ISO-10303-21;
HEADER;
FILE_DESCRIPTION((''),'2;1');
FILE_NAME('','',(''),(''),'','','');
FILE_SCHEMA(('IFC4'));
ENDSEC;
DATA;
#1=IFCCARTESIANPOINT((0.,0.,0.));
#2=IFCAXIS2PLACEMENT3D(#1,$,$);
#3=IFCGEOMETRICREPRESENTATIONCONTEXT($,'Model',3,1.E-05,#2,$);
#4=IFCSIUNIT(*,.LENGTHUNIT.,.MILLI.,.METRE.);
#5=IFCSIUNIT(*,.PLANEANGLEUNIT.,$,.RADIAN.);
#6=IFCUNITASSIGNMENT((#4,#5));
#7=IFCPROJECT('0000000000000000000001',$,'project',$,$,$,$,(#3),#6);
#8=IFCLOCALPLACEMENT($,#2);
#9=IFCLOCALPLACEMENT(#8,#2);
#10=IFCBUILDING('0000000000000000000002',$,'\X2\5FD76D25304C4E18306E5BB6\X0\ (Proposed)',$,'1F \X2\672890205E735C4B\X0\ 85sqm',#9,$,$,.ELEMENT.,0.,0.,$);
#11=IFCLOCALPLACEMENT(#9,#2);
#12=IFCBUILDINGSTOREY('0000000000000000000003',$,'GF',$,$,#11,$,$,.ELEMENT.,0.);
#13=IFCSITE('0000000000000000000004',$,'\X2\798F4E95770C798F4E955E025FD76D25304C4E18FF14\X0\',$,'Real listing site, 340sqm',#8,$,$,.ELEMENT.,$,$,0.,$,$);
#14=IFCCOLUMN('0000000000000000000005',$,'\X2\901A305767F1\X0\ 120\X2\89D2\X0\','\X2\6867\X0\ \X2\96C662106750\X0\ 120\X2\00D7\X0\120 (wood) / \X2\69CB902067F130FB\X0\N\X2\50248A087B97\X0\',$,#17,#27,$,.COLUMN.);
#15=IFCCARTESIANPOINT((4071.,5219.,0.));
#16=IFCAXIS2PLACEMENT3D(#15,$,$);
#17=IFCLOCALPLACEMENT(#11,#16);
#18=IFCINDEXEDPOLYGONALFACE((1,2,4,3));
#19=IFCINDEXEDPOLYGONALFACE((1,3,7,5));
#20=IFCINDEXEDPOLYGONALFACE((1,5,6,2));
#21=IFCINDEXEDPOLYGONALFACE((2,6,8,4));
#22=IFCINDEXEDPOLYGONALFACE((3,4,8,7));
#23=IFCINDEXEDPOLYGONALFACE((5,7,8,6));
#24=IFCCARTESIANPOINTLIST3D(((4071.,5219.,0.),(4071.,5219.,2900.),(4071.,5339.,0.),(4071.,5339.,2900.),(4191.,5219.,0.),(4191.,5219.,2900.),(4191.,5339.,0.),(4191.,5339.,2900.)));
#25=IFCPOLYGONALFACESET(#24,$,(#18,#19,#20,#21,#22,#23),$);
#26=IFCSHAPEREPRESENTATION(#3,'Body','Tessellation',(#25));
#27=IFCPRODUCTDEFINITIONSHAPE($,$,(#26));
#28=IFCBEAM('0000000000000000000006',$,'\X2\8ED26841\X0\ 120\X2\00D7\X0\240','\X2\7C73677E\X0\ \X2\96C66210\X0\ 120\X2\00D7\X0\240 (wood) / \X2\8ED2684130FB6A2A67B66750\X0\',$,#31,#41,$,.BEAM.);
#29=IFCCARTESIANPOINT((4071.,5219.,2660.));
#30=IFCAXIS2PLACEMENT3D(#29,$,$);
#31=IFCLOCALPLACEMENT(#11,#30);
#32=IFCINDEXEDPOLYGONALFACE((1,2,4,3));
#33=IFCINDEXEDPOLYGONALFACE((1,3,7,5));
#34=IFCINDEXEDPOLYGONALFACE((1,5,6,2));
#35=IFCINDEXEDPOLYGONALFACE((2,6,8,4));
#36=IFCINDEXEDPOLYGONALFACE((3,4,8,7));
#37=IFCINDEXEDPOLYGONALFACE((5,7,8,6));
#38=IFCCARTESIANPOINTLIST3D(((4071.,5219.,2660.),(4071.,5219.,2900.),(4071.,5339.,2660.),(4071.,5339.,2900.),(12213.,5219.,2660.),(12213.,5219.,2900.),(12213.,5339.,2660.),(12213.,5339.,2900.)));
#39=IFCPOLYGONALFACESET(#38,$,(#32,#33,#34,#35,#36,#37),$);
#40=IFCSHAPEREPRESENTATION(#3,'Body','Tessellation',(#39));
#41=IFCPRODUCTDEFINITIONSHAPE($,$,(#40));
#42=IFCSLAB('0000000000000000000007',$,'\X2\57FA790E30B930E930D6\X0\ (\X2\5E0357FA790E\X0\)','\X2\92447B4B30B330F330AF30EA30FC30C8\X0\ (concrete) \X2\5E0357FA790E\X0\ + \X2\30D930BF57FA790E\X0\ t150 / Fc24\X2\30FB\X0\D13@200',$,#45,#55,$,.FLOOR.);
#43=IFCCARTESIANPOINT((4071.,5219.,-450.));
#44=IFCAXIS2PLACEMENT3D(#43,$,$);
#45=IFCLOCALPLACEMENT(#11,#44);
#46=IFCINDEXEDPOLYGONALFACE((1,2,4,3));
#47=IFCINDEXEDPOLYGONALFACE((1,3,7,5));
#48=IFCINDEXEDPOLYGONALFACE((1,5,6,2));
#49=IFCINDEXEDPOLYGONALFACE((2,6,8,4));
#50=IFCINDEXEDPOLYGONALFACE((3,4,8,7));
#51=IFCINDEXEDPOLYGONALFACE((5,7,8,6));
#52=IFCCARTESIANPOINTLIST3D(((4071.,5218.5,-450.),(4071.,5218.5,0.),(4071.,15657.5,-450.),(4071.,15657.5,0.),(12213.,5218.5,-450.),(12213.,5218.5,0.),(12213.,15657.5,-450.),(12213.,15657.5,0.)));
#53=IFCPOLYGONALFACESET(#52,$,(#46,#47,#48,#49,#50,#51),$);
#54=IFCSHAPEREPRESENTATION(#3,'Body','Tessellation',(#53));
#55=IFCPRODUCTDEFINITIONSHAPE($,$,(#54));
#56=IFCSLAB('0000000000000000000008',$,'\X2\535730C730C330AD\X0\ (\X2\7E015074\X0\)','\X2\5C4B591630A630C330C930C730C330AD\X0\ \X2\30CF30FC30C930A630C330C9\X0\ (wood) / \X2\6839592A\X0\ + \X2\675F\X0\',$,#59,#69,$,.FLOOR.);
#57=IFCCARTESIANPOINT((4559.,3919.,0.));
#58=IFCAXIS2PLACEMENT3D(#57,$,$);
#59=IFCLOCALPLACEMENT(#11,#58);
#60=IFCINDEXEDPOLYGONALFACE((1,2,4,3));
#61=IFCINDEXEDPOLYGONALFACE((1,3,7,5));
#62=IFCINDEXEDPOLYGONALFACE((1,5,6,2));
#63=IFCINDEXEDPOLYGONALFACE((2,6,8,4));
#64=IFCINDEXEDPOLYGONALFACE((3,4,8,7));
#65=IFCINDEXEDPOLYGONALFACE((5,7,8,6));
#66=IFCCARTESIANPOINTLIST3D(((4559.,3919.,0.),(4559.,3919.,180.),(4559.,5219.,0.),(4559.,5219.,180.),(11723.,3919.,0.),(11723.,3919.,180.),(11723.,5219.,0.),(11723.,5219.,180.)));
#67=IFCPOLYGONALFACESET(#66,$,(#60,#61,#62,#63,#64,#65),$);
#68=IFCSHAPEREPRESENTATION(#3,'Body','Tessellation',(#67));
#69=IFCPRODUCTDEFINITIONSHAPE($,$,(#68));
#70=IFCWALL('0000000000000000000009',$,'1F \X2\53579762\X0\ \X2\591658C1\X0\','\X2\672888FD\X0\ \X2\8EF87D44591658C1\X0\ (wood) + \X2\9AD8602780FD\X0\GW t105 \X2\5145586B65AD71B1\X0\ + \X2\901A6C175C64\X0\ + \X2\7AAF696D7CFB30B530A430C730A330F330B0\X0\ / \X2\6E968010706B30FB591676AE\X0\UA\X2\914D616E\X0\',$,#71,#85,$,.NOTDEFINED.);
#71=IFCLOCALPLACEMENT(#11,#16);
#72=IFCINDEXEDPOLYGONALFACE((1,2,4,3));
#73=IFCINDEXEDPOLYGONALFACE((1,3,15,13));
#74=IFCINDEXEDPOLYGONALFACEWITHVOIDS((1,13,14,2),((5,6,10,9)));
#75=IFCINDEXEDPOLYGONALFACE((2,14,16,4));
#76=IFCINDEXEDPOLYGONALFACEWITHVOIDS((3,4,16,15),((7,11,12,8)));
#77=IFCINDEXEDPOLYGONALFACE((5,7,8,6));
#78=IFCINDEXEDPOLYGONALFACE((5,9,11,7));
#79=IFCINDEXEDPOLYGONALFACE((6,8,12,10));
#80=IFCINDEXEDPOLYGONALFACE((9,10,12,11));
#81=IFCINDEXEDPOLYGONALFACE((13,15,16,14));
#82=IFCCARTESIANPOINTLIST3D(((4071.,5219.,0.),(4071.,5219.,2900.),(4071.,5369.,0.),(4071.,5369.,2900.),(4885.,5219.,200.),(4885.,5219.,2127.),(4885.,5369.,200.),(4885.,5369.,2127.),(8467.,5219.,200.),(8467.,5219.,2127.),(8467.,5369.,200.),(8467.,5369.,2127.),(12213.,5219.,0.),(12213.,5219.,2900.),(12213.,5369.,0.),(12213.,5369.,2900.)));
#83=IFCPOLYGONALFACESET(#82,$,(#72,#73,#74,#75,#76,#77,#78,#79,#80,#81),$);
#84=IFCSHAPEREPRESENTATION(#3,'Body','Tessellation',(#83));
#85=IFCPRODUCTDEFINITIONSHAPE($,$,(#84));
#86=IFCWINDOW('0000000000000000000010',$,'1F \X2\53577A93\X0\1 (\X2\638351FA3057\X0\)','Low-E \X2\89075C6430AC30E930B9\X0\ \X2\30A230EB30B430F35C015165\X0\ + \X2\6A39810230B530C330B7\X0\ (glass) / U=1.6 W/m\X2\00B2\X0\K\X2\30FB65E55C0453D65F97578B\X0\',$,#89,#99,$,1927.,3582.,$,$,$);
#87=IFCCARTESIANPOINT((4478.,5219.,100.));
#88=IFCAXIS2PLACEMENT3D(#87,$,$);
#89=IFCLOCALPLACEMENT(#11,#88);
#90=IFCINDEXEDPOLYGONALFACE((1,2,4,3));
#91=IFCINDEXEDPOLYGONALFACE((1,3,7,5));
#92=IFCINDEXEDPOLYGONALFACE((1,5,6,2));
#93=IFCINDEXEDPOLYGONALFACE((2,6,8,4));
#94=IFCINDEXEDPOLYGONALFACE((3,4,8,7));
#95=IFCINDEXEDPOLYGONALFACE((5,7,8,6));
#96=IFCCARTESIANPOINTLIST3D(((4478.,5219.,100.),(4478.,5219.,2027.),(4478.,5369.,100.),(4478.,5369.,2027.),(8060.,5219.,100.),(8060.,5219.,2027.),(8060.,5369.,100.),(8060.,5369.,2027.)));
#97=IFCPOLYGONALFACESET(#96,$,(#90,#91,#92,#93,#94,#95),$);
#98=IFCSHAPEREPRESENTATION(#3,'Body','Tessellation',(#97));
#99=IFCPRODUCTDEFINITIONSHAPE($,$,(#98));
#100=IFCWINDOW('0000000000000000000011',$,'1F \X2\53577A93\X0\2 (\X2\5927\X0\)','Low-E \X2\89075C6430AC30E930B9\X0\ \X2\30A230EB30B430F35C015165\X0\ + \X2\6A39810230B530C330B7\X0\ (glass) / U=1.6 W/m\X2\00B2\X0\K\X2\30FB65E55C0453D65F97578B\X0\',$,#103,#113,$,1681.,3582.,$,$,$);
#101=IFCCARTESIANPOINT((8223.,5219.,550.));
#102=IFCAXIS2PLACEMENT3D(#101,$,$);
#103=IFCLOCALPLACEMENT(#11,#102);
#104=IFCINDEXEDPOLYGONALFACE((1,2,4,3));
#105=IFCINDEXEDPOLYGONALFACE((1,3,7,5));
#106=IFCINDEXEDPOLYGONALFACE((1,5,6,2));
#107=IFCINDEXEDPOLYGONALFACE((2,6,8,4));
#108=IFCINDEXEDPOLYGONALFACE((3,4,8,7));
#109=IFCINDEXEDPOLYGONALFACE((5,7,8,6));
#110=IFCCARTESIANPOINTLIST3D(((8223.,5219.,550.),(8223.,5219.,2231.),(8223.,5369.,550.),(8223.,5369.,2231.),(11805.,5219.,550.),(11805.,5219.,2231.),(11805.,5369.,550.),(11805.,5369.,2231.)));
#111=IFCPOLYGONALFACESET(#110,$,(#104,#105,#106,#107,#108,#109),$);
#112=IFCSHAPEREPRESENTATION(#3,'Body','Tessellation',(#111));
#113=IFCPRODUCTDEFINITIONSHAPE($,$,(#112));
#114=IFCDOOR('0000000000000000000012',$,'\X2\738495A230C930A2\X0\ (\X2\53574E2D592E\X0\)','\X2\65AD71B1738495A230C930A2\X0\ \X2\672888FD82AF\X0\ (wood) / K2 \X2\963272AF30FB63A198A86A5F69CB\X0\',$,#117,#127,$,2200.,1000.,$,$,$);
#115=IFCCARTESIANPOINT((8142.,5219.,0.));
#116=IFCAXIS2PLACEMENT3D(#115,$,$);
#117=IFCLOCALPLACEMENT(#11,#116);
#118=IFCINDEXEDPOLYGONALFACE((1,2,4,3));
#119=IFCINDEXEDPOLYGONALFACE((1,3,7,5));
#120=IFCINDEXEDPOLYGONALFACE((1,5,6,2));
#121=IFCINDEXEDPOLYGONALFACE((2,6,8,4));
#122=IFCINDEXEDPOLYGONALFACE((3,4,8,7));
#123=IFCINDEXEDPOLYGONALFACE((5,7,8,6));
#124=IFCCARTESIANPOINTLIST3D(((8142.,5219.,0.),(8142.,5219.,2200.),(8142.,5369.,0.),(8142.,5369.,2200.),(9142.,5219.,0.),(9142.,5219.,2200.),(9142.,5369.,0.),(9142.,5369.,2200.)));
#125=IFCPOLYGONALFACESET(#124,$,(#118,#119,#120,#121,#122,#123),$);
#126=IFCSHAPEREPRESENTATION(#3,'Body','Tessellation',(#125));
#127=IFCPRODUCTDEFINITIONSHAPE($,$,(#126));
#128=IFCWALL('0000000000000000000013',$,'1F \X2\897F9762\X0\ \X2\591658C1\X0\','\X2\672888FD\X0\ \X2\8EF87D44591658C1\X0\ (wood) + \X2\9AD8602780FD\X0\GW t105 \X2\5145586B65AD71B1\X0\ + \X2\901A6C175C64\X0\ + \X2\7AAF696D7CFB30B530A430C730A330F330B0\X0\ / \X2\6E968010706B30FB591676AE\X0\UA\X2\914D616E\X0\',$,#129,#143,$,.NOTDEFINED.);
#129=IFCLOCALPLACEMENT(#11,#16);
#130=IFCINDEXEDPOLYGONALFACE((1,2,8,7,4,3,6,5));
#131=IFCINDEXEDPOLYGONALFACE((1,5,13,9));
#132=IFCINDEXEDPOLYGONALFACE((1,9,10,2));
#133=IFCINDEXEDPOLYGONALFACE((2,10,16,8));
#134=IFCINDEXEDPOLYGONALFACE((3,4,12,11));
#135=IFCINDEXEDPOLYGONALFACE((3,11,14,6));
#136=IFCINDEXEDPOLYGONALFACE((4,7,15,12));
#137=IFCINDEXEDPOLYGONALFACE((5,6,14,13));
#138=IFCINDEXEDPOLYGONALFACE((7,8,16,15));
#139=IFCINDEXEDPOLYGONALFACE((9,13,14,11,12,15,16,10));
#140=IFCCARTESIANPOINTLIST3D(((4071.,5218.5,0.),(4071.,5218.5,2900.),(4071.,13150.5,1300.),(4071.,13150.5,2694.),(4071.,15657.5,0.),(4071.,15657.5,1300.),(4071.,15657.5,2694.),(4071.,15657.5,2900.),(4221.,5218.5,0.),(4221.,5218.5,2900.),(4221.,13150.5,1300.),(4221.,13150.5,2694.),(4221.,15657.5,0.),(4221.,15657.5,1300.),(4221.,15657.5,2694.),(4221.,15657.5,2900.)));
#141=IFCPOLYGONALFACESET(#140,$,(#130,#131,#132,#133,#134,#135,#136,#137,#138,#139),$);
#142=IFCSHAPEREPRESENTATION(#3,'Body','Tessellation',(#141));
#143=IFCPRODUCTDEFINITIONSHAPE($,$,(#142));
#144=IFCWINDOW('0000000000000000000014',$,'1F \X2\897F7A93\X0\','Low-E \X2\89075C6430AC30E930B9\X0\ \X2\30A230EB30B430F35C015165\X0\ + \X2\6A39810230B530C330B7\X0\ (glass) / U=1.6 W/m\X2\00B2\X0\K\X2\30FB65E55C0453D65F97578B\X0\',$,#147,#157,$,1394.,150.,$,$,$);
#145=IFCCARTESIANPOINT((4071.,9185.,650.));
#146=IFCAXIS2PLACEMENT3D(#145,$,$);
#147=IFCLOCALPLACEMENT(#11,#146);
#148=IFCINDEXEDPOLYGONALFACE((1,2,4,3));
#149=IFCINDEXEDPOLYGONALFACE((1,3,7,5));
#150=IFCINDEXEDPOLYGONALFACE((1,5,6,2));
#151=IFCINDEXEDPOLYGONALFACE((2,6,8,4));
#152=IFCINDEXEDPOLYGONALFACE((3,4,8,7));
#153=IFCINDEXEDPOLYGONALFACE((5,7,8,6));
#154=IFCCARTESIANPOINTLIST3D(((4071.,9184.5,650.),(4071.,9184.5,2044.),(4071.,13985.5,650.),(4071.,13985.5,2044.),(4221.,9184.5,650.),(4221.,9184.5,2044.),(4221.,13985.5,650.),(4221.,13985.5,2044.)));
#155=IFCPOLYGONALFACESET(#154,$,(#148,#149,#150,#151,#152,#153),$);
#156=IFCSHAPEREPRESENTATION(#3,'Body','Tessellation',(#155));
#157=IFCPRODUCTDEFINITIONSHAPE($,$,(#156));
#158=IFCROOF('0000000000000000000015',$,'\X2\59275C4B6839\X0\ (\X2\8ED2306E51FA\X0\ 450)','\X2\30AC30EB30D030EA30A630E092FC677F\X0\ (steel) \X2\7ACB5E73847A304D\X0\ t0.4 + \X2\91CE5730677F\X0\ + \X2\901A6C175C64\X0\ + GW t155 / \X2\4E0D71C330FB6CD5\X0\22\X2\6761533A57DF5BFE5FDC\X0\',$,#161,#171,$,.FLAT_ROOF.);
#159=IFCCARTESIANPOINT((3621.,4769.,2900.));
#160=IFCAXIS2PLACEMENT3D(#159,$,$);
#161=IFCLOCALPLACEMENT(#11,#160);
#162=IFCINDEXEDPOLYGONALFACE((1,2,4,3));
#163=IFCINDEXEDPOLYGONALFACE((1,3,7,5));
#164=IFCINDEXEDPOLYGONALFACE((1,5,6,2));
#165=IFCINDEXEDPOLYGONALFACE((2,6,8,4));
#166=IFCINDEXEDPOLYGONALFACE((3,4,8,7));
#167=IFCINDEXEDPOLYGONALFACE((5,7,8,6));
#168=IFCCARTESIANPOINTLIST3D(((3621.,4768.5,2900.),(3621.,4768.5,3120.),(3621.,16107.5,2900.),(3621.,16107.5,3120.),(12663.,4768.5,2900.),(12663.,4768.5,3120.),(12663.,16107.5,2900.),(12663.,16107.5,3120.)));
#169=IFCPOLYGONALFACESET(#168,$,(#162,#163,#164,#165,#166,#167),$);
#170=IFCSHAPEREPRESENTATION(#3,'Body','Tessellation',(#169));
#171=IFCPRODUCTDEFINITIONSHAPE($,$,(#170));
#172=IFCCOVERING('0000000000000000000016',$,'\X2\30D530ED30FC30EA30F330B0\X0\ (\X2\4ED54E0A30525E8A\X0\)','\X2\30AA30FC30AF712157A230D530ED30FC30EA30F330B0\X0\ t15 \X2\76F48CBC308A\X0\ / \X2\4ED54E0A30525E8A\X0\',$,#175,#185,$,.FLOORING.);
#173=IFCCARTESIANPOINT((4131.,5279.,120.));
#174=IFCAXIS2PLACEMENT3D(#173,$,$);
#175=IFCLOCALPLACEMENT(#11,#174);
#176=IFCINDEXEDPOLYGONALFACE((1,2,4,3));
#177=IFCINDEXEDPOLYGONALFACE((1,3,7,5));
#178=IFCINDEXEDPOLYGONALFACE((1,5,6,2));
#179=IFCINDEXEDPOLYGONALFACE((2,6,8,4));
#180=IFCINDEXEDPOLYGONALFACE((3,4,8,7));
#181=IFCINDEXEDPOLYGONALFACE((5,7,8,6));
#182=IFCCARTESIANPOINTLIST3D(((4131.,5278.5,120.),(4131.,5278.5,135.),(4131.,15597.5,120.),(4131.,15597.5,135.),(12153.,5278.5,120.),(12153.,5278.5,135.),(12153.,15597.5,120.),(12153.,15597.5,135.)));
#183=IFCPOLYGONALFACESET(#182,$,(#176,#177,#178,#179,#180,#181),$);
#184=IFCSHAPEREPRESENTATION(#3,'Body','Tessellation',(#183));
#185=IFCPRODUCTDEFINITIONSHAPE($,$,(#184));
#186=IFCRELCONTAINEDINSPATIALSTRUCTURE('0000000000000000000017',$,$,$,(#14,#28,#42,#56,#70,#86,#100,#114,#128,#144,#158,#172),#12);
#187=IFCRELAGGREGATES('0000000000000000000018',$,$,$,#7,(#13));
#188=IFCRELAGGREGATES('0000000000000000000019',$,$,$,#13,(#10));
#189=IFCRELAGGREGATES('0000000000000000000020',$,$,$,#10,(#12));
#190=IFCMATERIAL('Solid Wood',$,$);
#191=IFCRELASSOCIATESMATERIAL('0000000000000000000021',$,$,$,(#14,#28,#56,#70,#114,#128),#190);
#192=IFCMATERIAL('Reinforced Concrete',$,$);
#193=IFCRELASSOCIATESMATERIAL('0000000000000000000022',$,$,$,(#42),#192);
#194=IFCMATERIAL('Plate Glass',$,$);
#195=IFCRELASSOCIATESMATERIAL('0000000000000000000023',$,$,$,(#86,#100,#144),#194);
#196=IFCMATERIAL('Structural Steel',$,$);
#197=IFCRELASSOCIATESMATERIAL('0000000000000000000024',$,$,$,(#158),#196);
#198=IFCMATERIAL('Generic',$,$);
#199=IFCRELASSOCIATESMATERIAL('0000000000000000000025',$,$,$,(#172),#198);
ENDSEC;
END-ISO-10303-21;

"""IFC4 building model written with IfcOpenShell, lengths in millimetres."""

from ifc_helpers import new_model, si_unit, frame, frame_2d, origin, place, context, project, spatial, rectangle, extrude, material, element, fill, save


model = new_model("IFC4")

# Units and contexts
model_context = context("Model", 3, precision=1e-05, world=origin())
ifc_project = project(units=[si_unit("LENGTHUNIT", "METRE", prefix="MILLI"), si_unit("PLANEANGLEUNIT", "RADIAN")], contexts=[model_context])

# Site, building, storey
site_placement = place(None, origin())
site = spatial("IfcSite", under=ifc_project, at=site_placement, Name="福井県福井市志津が丘４", ObjectType="Real listing site, 340sqm", CompositionType="ELEMENT", RefElevation=0.0)
building_placement = place(site_placement, origin())
building = spatial("IfcBuilding", under=site, at=building_placement, Name="志津が丘の家 (Proposed)", ObjectType="1F 木造平屋 85sqm", CompositionType="ELEMENT", ElevationOfRefHeight=0.0, ElevationOfTerrain=0.0)
storey_placement = place(building_placement, origin())
storey = spatial("IfcBuildingStorey", under=building, at=storey_placement, Name="GF", CompositionType="ELEMENT", Elevation=0.0)

# Column
ifc_material_1 = material(Name="Solid Wood")
column_1_placement = place(storey_placement, frame((4071.0, 5219.0, 0.0)))
element("IfcColumn", 1, at=column_1_placement, inside=storey, material=ifc_material_1, Name="通し柱 120角", Description="桧 集成材 120×120 (wood) / 構造柱・N値計算", PredefinedType="COLUMN", context=model_context, shape_type="SweptSolid", body=[
    extrude(rectangle(XDim=120.0, YDim=120.0, at=frame_2d((60.0, 60.0))), frame((4071.0, 5219.0, 0.0)), (0.0, 0.0, 1.0), 2900.0),
])

# Beam
beam_1_placement = place(storey_placement, frame((4071.0, 5219.0, 2660.0)))
element("IfcBeam", 2, at=beam_1_placement, inside=storey, material=ifc_material_1, Name="軒桁 120×240", Description="米松 集成 120×240 (wood) / 軒桁・横架材", PredefinedType="BEAM", context=model_context, shape_type="SweptSolid", body=[
    extrude(rectangle(XDim=8142.0, YDim=120.0, at=frame_2d((4071.0, 60.0))), frame((4071.0, 5219.0, 2660.0)), (0.0, 0.0, 1.0), 240.0),
])

# Slabs
ifc_material_2 = material(Name="Reinforced Concrete")
slab_1_placement = place(storey_placement, frame((4071.0, 5219.0, -450.0)))
element("IfcSlab", 3, at=slab_1_placement, inside=storey, material=ifc_material_2, Name="基礎スラブ (布基礎)", Description="鉄筋コンクリート (concrete) 布基礎 + ベタ基礎 t150 / Fc24・D13@200", PredefinedType="FLOOR", context=model_context, shape_type="SweptSolid", body=[
    extrude(rectangle(XDim=8142.0, YDim=10439.0, at=frame_2d((4071.0, 5219.0))), frame((4071.0, 5219.0, -450.0)), (0.0, 0.0, 1.0), 450.0),
])
slab_2_placement = place(storey_placement, frame((4559.0, 3919.0, 0.0)))
element("IfcSlab", 4, at=slab_2_placement, inside=storey, material=ifc_material_1, Name="南デッキ (縁側)", Description="屋外ウッドデッキ ハードウッド (wood) / 根太 + 束", PredefinedType="FLOOR", context=model_context, shape_type="SweptSolid", body=[
    extrude(rectangle(XDim=7164.0, YDim=1300.0, at=frame_2d((3582.0, 650.0))), frame((4559.0, 3919.0, 0.0)), (0.0, 0.0, 1.0), 180.0),
])

# Wall, openings, windows, door
wall_1_placement = place(storey_placement, frame((4071.0, 5219.0, 0.0)))
wall_1 = element("IfcWall", 5, at=wall_1_placement, inside=storey, material=ifc_material_1, Name="1F 南面 外壁", Description="木製 軸組外壁 (wood) + 高性能GW t105 充填断熱 + 通気層 + 窯業系サイディング / 準耐火・外皮UA配慮", PredefinedType="NOTDEFINED", context=model_context, shape_type="SweptSolid", body=[
    extrude(rectangle(XDim=8142.0, YDim=150.0, at=frame_2d((4071.0, 75.0))), frame((4071.0, 5219.0, 0.0)), (0.0, 0.0, 1.0), 2900.0),
])
opening_1_placement = place(storey_placement, frame((4478.0, 5219.0, 100.0)))
opening_1 = element("IfcOpeningElement", 6, at=opening_1_placement, cuts=wall_1, PredefinedType="NOTDEFINED", context=model_context, shape_type="SweptSolid", body=[
    extrude(rectangle(XDim=3582.0, YDim=150.0, at=frame_2d((1791.0, 75.0))), frame((4478.0, 5219.0, 100.0)), (0.0, 0.0, 1.0), 1927.0),
])
opening_2_placement = place(storey_placement, frame((8223.0, 5219.0, 550.0)))
opening_2 = element("IfcOpeningElement", 7, at=opening_2_placement, cuts=wall_1, PredefinedType="NOTDEFINED", context=model_context, shape_type="SweptSolid", body=[
    extrude(rectangle(XDim=3582.0, YDim=150.0, at=frame_2d((1791.0, 75.0))), frame((8223.0, 5219.0, 550.0)), (0.0, 0.0, 1.0), 1681.0),
])
opening_3_placement = place(storey_placement, frame((8142.0, 5219.0, 0.0)))
opening_3 = element("IfcOpeningElement", 8, at=opening_3_placement, cuts=wall_1, PredefinedType="NOTDEFINED", context=model_context, shape_type="SweptSolid", body=[
    extrude(rectangle(XDim=1000.0, YDim=150.0, at=frame_2d((500.0, 75.0))), frame((8142.0, 5219.0, 0.0)), (0.0, 0.0, 1.0), 2200.0),
])
ifc_material_3 = material(Name="Plate Glass")
window_1_placement = place(storey_placement, frame((4478.0, 5219.0, 100.0)))
window_1 = element("IfcWindow", 9, at=window_1_placement, inside=storey, material=ifc_material_3, Name="1F 南窓1 (掃出し)", Description="Low-E 複層ガラス アルゴン封入 + 樹脂サッシ (glass) / U=1.6 W/m²K・日射取得型", OverallHeight=1927.0, OverallWidth=3582.0, context=model_context, shape_type="SweptSolid", body=[
    extrude(rectangle(XDim=3582.0, YDim=150.0, at=frame_2d((1791.0, 75.0))), frame((4478.0, 5219.0, 100.0)), (0.0, 0.0, 1.0), 1927.0),
])
fill(opening_1, window_1)
window_2_placement = place(storey_placement, frame((8223.0, 5219.0, 550.0)))
window_2 = element("IfcWindow", 10, at=window_2_placement, inside=storey, material=ifc_material_3, Name="1F 南窓2 (大)", Description="Low-E 複層ガラス アルゴン封入 + 樹脂サッシ (glass) / U=1.6 W/m²K・日射取得型", OverallHeight=1681.0, OverallWidth=3582.0, context=model_context, shape_type="SweptSolid", body=[
    extrude(rectangle(XDim=3582.0, YDim=150.0, at=frame_2d((1791.0, 75.0))), frame((8223.0, 5219.0, 550.0)), (0.0, 0.0, 1.0), 1681.0),
])
fill(opening_2, window_2)
door_placement = place(storey_placement, frame((8142.0, 5219.0, 0.0)))
door = element("IfcDoor", 11, at=door_placement, inside=storey, material=ifc_material_1, Name="玄関ドア (南中央)", Description="断熱玄関ドア 木製芯 (wood) / K2 防犯・採風機構", OverallHeight=2200.0, OverallWidth=1000.0, context=model_context, shape_type="SweptSolid", body=[
    extrude(rectangle(XDim=1000.0, YDim=150.0, at=frame_2d((500.0, 75.0))), frame((8142.0, 5219.0, 0.0)), (0.0, 0.0, 1.0), 2200.0),
])
fill(opening_3, door)

# Wall, opening, window
wall_2_placement = place(storey_placement, frame((4071.0, 5219.0, 0.0)))
wall_2 = element("IfcWall", 12, at=wall_2_placement, inside=storey, material=ifc_material_1, Name="1F 西面 外壁", Description="木製 軸組外壁 (wood) + 高性能GW t105 充填断熱 + 通気層 + 窯業系サイディング / 準耐火・外皮UA配慮", PredefinedType="NOTDEFINED", context=model_context, shape_type="SweptSolid", body=[
    extrude(rectangle(XDim=150.0, YDim=10439.0, at=frame_2d((75.0, 5219.0))), frame((4071.0, 5219.0, 0.0)), (0.0, 0.0, 1.0), 2900.0),
])
opening_4_placement = place(storey_placement, frame((4071.0, 9185.0, 650.0)))
opening_4 = element("IfcOpeningElement", 13, at=opening_4_placement, cuts=wall_2, PredefinedType="NOTDEFINED", context=model_context, shape_type="SweptSolid", body=[
    extrude(rectangle(XDim=150.0, YDim=4801.0, at=frame_2d((75.0, 2400.0))), frame((4071.0, 9185.0, 650.0)), (0.0, 0.0, 1.0), 1394.0),
])
window_3_placement = place(storey_placement, frame((4071.0, 9185.0, 650.0)))
window_3 = element("IfcWindow", 14, at=window_3_placement, inside=storey, material=ifc_material_3, Name="1F 西窓", Description="Low-E 複層ガラス アルゴン封入 + 樹脂サッシ (glass) / U=1.6 W/m²K・日射取得型", OverallHeight=1394.0, OverallWidth=150.0, context=model_context, shape_type="SweptSolid", body=[
    extrude(rectangle(XDim=150.0, YDim=4801.0, at=frame_2d((75.0, 2400.0))), frame((4071.0, 9185.0, 650.0)), (0.0, 0.0, 1.0), 1394.0),
])
fill(opening_4, window_3)

# Roof
ifc_material_4 = material(Name="Structural Steel")
roof_placement = place(storey_placement, frame((3621.0, 4769.0, 2900.0)))
element("IfcRoof", 15, at=roof_placement, inside=storey, material=ifc_material_4, Name="大屋根 (軒の出 450)", Description="ガルバリウム鋼板 (steel) 立平葺き t0.4 + 野地板 + 通気層 + GW t155 / 不燃・法22条区域対応", PredefinedType="FLAT_ROOF", context=model_context, shape_type="SweptSolid", body=[
    extrude(rectangle(XDim=9042.0, YDim=11339.0, at=frame_2d((4521.0, 5669.0))), frame((3621.0, 4769.0, 2900.0)), (0.0, 0.0, 1.0), 220.0),
])

# Covering
ifc_material_5 = material(Name="Generic")
covering_1_placement = place(storey_placement, frame((4131.0, 5279.0, 120.0)))
element("IfcCovering", 16, at=covering_1_placement, inside=storey, material=ifc_material_5, Name="フローリング (仕上げ床)", Description="オーク無垢フローリング t15 直貼り / 仕上げ床", PredefinedType="FLOORING", context=model_context, shape_type="SweptSolid", body=[
    extrude(rectangle(XDim=8022.0, YDim=10319.0, at=frame_2d((4011.0, 5159.0))), frame((4131.0, 5279.0, 120.0)), (0.0, 0.0, 1.0), 15.0),
])

save(model, "model.ifc")
